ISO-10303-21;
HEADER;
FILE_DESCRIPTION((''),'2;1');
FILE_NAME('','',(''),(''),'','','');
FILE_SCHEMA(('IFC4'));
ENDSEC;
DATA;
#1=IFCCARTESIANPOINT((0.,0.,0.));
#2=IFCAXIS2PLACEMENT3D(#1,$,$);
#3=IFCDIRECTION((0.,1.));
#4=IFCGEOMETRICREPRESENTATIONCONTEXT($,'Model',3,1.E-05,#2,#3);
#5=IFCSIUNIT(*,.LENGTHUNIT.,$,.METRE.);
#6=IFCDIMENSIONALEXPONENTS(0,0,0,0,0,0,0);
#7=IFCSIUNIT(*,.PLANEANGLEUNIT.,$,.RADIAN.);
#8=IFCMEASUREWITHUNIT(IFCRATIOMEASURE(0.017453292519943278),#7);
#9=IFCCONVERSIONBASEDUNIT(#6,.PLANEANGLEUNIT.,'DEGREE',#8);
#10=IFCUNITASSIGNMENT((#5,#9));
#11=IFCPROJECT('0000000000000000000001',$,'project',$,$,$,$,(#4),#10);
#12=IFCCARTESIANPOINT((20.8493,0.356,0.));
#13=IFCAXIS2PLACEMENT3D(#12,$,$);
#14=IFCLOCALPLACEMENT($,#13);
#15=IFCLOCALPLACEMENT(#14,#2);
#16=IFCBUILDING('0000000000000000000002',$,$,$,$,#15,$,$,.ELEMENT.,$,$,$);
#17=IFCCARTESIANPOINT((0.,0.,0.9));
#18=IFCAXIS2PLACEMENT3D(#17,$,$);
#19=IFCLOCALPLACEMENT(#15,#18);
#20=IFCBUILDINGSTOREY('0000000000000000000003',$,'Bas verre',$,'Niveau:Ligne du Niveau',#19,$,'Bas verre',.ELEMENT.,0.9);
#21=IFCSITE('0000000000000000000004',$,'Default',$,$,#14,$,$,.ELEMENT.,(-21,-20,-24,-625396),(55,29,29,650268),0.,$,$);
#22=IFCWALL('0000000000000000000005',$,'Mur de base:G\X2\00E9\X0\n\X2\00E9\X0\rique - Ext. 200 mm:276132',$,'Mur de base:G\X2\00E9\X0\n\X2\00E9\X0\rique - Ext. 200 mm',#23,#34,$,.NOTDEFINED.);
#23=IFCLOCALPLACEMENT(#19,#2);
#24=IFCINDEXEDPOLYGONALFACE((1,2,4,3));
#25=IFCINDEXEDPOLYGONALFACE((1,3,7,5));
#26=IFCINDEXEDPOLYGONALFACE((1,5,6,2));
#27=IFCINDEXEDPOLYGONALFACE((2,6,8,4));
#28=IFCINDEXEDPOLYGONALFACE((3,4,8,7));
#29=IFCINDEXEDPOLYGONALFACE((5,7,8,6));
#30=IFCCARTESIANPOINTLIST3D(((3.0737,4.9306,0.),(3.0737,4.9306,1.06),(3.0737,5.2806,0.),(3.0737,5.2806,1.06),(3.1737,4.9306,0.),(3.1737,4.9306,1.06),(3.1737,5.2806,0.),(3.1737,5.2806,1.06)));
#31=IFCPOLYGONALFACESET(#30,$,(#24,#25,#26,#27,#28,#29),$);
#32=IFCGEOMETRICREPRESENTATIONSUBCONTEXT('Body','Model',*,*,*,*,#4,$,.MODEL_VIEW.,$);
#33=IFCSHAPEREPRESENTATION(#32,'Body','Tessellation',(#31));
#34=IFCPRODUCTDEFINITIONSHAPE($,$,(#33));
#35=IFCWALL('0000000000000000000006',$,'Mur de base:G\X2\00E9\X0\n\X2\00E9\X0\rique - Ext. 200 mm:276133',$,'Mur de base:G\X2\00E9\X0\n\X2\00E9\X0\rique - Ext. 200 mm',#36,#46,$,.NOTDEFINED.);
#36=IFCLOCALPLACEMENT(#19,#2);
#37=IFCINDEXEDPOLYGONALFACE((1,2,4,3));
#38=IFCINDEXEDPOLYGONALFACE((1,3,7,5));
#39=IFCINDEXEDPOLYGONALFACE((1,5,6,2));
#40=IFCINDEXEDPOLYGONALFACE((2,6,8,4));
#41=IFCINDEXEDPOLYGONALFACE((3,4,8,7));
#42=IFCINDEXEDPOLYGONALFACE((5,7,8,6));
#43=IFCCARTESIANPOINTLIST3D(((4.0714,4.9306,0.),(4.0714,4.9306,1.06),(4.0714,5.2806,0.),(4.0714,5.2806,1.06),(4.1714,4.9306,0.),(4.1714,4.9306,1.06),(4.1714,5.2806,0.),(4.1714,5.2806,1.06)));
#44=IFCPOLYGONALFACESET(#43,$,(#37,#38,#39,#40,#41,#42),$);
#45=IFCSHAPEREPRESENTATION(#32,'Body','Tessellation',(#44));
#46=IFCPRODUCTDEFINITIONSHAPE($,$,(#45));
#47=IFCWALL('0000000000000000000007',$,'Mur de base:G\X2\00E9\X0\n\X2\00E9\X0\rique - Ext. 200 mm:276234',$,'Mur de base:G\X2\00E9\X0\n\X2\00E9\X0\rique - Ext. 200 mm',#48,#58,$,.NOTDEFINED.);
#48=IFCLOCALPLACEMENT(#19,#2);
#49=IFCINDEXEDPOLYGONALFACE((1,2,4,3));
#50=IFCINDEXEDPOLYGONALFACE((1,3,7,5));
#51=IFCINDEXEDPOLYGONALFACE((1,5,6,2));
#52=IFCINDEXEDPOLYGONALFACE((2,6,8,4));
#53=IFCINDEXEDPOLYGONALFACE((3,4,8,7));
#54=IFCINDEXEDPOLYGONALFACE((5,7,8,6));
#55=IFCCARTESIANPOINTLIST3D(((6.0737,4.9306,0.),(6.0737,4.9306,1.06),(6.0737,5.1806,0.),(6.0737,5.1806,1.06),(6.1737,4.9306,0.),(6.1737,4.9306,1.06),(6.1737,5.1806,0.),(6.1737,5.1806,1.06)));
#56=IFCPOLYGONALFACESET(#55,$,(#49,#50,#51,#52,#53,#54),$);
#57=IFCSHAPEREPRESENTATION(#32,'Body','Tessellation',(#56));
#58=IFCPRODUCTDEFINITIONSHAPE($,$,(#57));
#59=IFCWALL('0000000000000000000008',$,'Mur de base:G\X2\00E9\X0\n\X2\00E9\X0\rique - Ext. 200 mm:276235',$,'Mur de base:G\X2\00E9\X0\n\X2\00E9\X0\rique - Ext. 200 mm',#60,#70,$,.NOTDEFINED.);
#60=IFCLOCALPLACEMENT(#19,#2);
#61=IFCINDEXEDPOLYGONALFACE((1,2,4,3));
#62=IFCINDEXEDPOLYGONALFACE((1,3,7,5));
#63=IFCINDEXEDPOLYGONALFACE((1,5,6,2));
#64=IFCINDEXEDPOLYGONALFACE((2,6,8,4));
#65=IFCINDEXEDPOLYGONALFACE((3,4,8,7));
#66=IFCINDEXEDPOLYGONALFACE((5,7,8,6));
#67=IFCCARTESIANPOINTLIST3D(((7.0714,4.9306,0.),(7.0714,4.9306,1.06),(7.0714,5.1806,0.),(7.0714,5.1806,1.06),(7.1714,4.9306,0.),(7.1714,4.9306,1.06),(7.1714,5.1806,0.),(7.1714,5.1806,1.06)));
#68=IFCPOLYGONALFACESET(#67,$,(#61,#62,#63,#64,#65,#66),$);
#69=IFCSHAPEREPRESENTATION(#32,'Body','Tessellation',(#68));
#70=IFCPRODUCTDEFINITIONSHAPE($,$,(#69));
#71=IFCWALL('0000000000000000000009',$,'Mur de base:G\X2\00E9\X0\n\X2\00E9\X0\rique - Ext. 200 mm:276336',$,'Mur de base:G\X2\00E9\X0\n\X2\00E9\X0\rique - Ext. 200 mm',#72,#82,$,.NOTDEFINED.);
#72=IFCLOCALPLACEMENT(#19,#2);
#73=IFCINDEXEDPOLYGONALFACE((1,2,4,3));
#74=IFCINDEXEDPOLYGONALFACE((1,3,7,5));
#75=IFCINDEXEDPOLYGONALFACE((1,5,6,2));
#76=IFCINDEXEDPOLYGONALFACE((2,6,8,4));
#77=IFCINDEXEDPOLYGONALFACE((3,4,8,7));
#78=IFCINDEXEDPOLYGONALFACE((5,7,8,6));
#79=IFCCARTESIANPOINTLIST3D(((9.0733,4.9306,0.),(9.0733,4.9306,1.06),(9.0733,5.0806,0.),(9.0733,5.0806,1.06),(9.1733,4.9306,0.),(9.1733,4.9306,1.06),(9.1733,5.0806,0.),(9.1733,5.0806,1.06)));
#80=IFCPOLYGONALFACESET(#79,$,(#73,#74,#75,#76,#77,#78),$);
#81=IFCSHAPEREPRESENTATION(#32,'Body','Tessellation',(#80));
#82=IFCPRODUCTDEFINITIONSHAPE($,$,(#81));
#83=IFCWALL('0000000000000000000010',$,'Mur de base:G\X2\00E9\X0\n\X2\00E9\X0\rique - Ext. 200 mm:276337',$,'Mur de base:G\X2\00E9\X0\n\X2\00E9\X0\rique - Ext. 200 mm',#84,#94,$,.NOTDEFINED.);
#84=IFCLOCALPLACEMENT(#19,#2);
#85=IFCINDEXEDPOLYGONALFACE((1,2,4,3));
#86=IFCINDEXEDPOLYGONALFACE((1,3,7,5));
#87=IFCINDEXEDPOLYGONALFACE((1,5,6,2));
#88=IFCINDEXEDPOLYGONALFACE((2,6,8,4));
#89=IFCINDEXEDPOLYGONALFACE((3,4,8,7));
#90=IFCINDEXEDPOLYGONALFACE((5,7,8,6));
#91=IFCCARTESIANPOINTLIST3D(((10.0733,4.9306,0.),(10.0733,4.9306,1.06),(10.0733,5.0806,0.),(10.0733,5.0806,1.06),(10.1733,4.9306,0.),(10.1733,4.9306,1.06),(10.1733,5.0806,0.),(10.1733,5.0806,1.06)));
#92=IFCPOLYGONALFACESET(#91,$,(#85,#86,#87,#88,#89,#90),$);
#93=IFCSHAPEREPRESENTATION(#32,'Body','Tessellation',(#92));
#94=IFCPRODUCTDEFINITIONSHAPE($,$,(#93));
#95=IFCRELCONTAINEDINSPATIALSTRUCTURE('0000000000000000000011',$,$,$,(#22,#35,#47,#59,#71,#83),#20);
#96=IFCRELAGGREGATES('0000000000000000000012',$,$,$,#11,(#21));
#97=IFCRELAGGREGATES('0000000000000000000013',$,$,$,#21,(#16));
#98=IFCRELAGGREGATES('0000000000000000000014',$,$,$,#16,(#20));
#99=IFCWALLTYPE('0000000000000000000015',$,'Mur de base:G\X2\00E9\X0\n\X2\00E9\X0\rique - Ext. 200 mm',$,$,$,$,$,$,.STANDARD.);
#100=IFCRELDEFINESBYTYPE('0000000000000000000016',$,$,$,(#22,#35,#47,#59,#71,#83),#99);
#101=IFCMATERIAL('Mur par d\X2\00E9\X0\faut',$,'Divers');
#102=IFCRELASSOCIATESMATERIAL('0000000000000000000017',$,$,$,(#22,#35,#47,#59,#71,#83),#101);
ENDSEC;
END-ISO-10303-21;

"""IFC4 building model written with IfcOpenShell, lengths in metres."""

from ifc_helpers import new_model, entity, si_unit, converted_unit, direction, frame, origin, place, context, subcontext, project, spatial, indexed_curve, outline, extrude, material, type_object, element, save


model = new_model("IFC4")

# Units and contexts
model_context = context("Model", 3, precision=1e-05, world=origin(), true_north=direction((0.0, 1.0)))
body_context = subcontext(model_context, "Body", "Model", "MODEL_VIEW")
ifc_project = project(units=[si_unit("LENGTHUNIT", "METRE"), converted_unit("PLANEANGLEUNIT", "DEGREE", entity("IfcRatioMeasure", 0.017453292519943278), si_unit("PLANEANGLEUNIT", "RADIAN"), dimensions=[0, 0, 0, 0, 0, 0, 0])], contexts=[model_context])

# Site, building, storey
site_placement = place(None, frame((20.8493, 0.356, 0.0)))
site = spatial("IfcSite", under=ifc_project, at=site_placement, Name="Default", CompositionType="ELEMENT", RefLatitude=(-21, -20, -24, -625396), RefLongitude=(55, 29, 29, 650268), RefElevation=0.0)
building_placement = place(site_placement, origin())
building = spatial("IfcBuilding", under=site, at=building_placement, CompositionType="ELEMENT")
storey_placement = place(building_placement, frame((0.0, 0.0, 0.9)))
storey = spatial("IfcBuildingStorey", under=building, at=storey_placement, Name="Bas verre", ObjectType="Niveau:Ligne du Niveau", LongName="Bas verre", CompositionType="ELEMENT", Elevation=0.9)

# Walls
ifc_material = material(Name="Mur par défaut", Category="Divers")
wall_type = type_object("IfcWallType", Name="Mur de base:Générique - Ext. 200 mm", PredefinedType="STANDARD")
wall_1_placement = place(storey_placement, frame((3.1237, 4.9306, 0.0), z_axis=(0.0, 0.0, 1.0), x_axis=(0.0, 1.0, 0.0)))
element("IfcWall", 1, at=wall_1_placement, inside=storey, type_object=wall_type, material=ifc_material, Name="Mur de base:Générique - Ext. 200 mm:276132", ObjectType="Mur de base:Générique - Ext. 200 mm", PredefinedType="NOTDEFINED", context=body_context, shape_type="SweptSolid", body=[
    extrude(outline(indexed_curve([(0.35, 0.05), (0.0, 0.05), (0.0, -0.05), (0.35, -0.05), (0.35, 0.05)], self_intersect=False)), origin(), (0.0, 0.0, 1.0), 1.06),
])
wall_2_placement = place(storey_placement, frame((4.1214, 4.9306, 0.0), z_axis=(0.0, 0.0, 1.0), x_axis=(0.0, 1.0, 0.0)))
element("IfcWall", 2, at=wall_2_placement, inside=storey, type_object=wall_type, material=ifc_material, Name="Mur de base:Générique - Ext. 200 mm:276133", ObjectType="Mur de base:Générique - Ext. 200 mm", PredefinedType="NOTDEFINED", context=body_context, shape_type="SweptSolid", body=[
    extrude(outline(indexed_curve([(0.35, 0.05), (0.0, 0.05), (0.0, -0.05), (0.35, -0.05), (0.35, 0.05)], self_intersect=False)), origin(), (0.0, 0.0, 1.0), 1.06),
])
wall_3_placement = place(storey_placement, frame((6.1237, 4.9306, 0.0), z_axis=(0.0, 0.0, 1.0), x_axis=(0.0, 1.0, 0.0)))
element("IfcWall", 3, at=wall_3_placement, inside=storey, type_object=wall_type, material=ifc_material, Name="Mur de base:Générique - Ext. 200 mm:276234", ObjectType="Mur de base:Générique - Ext. 200 mm", PredefinedType="NOTDEFINED", context=body_context, shape_type="SweptSolid", body=[
    extrude(outline(indexed_curve([(0.25, 0.05), (0.0, 0.05), (0.0, -0.05), (0.25, -0.05), (0.25, 0.05)], self_intersect=False)), origin(), (0.0, 0.0, 1.0), 1.06),
])
wall_4_placement = place(storey_placement, frame((7.1214, 4.9306, 0.0), z_axis=(0.0, 0.0, 1.0), x_axis=(0.0, 1.0, 0.0)))
element("IfcWall", 4, at=wall_4_placement, inside=storey, type_object=wall_type, material=ifc_material, Name="Mur de base:Générique - Ext. 200 mm:276235", ObjectType="Mur de base:Générique - Ext. 200 mm", PredefinedType="NOTDEFINED", context=body_context, shape_type="SweptSolid", body=[
    extrude(outline(indexed_curve([(0.25, 0.05), (0.0, 0.05), (0.0, -0.05), (0.25, -0.05), (0.25, 0.05)], self_intersect=False)), origin(), (0.0, 0.0, 1.0), 1.06),
])
wall_5_placement = place(storey_placement, frame((9.1233, 4.9306, 0.0), z_axis=(0.0, 0.0, 1.0), x_axis=(0.0, 1.0, 0.0)))
element("IfcWall", 5, at=wall_5_placement, inside=storey, type_object=wall_type, material=ifc_material, Name="Mur de base:Générique - Ext. 200 mm:276336", ObjectType="Mur de base:Générique - Ext. 200 mm", PredefinedType="NOTDEFINED", context=body_context, shape_type="SweptSolid", body=[
    extrude(outline(indexed_curve([(0.15, 0.05), (0.0, 0.05), (0.0, -0.05), (0.15, -0.05), (0.15, 0.05)], self_intersect=False)), origin(), (0.0, 0.0, 1.0), 1.06),
])
wall_6_placement = place(storey_placement, frame((10.1233, 4.9306, 0.0), z_axis=(0.0, 0.0, 1.0), x_axis=(0.0, 1.0, 0.0)))
element("IfcWall", 6, at=wall_6_placement, inside=storey, type_object=wall_type, material=ifc_material, Name="Mur de base:Générique - Ext. 200 mm:276337", ObjectType="Mur de base:Générique - Ext. 200 mm", PredefinedType="NOTDEFINED", context=body_context, shape_type="SweptSolid", body=[
    extrude(outline(indexed_curve([(0.15, 0.05), (0.0, 0.05), (0.0, -0.05), (0.15, -0.05), (0.15, 0.05)], self_intersect=False)), origin(), (0.0, 0.0, 1.0), 1.06),
])

save(model, "model.ifc")
